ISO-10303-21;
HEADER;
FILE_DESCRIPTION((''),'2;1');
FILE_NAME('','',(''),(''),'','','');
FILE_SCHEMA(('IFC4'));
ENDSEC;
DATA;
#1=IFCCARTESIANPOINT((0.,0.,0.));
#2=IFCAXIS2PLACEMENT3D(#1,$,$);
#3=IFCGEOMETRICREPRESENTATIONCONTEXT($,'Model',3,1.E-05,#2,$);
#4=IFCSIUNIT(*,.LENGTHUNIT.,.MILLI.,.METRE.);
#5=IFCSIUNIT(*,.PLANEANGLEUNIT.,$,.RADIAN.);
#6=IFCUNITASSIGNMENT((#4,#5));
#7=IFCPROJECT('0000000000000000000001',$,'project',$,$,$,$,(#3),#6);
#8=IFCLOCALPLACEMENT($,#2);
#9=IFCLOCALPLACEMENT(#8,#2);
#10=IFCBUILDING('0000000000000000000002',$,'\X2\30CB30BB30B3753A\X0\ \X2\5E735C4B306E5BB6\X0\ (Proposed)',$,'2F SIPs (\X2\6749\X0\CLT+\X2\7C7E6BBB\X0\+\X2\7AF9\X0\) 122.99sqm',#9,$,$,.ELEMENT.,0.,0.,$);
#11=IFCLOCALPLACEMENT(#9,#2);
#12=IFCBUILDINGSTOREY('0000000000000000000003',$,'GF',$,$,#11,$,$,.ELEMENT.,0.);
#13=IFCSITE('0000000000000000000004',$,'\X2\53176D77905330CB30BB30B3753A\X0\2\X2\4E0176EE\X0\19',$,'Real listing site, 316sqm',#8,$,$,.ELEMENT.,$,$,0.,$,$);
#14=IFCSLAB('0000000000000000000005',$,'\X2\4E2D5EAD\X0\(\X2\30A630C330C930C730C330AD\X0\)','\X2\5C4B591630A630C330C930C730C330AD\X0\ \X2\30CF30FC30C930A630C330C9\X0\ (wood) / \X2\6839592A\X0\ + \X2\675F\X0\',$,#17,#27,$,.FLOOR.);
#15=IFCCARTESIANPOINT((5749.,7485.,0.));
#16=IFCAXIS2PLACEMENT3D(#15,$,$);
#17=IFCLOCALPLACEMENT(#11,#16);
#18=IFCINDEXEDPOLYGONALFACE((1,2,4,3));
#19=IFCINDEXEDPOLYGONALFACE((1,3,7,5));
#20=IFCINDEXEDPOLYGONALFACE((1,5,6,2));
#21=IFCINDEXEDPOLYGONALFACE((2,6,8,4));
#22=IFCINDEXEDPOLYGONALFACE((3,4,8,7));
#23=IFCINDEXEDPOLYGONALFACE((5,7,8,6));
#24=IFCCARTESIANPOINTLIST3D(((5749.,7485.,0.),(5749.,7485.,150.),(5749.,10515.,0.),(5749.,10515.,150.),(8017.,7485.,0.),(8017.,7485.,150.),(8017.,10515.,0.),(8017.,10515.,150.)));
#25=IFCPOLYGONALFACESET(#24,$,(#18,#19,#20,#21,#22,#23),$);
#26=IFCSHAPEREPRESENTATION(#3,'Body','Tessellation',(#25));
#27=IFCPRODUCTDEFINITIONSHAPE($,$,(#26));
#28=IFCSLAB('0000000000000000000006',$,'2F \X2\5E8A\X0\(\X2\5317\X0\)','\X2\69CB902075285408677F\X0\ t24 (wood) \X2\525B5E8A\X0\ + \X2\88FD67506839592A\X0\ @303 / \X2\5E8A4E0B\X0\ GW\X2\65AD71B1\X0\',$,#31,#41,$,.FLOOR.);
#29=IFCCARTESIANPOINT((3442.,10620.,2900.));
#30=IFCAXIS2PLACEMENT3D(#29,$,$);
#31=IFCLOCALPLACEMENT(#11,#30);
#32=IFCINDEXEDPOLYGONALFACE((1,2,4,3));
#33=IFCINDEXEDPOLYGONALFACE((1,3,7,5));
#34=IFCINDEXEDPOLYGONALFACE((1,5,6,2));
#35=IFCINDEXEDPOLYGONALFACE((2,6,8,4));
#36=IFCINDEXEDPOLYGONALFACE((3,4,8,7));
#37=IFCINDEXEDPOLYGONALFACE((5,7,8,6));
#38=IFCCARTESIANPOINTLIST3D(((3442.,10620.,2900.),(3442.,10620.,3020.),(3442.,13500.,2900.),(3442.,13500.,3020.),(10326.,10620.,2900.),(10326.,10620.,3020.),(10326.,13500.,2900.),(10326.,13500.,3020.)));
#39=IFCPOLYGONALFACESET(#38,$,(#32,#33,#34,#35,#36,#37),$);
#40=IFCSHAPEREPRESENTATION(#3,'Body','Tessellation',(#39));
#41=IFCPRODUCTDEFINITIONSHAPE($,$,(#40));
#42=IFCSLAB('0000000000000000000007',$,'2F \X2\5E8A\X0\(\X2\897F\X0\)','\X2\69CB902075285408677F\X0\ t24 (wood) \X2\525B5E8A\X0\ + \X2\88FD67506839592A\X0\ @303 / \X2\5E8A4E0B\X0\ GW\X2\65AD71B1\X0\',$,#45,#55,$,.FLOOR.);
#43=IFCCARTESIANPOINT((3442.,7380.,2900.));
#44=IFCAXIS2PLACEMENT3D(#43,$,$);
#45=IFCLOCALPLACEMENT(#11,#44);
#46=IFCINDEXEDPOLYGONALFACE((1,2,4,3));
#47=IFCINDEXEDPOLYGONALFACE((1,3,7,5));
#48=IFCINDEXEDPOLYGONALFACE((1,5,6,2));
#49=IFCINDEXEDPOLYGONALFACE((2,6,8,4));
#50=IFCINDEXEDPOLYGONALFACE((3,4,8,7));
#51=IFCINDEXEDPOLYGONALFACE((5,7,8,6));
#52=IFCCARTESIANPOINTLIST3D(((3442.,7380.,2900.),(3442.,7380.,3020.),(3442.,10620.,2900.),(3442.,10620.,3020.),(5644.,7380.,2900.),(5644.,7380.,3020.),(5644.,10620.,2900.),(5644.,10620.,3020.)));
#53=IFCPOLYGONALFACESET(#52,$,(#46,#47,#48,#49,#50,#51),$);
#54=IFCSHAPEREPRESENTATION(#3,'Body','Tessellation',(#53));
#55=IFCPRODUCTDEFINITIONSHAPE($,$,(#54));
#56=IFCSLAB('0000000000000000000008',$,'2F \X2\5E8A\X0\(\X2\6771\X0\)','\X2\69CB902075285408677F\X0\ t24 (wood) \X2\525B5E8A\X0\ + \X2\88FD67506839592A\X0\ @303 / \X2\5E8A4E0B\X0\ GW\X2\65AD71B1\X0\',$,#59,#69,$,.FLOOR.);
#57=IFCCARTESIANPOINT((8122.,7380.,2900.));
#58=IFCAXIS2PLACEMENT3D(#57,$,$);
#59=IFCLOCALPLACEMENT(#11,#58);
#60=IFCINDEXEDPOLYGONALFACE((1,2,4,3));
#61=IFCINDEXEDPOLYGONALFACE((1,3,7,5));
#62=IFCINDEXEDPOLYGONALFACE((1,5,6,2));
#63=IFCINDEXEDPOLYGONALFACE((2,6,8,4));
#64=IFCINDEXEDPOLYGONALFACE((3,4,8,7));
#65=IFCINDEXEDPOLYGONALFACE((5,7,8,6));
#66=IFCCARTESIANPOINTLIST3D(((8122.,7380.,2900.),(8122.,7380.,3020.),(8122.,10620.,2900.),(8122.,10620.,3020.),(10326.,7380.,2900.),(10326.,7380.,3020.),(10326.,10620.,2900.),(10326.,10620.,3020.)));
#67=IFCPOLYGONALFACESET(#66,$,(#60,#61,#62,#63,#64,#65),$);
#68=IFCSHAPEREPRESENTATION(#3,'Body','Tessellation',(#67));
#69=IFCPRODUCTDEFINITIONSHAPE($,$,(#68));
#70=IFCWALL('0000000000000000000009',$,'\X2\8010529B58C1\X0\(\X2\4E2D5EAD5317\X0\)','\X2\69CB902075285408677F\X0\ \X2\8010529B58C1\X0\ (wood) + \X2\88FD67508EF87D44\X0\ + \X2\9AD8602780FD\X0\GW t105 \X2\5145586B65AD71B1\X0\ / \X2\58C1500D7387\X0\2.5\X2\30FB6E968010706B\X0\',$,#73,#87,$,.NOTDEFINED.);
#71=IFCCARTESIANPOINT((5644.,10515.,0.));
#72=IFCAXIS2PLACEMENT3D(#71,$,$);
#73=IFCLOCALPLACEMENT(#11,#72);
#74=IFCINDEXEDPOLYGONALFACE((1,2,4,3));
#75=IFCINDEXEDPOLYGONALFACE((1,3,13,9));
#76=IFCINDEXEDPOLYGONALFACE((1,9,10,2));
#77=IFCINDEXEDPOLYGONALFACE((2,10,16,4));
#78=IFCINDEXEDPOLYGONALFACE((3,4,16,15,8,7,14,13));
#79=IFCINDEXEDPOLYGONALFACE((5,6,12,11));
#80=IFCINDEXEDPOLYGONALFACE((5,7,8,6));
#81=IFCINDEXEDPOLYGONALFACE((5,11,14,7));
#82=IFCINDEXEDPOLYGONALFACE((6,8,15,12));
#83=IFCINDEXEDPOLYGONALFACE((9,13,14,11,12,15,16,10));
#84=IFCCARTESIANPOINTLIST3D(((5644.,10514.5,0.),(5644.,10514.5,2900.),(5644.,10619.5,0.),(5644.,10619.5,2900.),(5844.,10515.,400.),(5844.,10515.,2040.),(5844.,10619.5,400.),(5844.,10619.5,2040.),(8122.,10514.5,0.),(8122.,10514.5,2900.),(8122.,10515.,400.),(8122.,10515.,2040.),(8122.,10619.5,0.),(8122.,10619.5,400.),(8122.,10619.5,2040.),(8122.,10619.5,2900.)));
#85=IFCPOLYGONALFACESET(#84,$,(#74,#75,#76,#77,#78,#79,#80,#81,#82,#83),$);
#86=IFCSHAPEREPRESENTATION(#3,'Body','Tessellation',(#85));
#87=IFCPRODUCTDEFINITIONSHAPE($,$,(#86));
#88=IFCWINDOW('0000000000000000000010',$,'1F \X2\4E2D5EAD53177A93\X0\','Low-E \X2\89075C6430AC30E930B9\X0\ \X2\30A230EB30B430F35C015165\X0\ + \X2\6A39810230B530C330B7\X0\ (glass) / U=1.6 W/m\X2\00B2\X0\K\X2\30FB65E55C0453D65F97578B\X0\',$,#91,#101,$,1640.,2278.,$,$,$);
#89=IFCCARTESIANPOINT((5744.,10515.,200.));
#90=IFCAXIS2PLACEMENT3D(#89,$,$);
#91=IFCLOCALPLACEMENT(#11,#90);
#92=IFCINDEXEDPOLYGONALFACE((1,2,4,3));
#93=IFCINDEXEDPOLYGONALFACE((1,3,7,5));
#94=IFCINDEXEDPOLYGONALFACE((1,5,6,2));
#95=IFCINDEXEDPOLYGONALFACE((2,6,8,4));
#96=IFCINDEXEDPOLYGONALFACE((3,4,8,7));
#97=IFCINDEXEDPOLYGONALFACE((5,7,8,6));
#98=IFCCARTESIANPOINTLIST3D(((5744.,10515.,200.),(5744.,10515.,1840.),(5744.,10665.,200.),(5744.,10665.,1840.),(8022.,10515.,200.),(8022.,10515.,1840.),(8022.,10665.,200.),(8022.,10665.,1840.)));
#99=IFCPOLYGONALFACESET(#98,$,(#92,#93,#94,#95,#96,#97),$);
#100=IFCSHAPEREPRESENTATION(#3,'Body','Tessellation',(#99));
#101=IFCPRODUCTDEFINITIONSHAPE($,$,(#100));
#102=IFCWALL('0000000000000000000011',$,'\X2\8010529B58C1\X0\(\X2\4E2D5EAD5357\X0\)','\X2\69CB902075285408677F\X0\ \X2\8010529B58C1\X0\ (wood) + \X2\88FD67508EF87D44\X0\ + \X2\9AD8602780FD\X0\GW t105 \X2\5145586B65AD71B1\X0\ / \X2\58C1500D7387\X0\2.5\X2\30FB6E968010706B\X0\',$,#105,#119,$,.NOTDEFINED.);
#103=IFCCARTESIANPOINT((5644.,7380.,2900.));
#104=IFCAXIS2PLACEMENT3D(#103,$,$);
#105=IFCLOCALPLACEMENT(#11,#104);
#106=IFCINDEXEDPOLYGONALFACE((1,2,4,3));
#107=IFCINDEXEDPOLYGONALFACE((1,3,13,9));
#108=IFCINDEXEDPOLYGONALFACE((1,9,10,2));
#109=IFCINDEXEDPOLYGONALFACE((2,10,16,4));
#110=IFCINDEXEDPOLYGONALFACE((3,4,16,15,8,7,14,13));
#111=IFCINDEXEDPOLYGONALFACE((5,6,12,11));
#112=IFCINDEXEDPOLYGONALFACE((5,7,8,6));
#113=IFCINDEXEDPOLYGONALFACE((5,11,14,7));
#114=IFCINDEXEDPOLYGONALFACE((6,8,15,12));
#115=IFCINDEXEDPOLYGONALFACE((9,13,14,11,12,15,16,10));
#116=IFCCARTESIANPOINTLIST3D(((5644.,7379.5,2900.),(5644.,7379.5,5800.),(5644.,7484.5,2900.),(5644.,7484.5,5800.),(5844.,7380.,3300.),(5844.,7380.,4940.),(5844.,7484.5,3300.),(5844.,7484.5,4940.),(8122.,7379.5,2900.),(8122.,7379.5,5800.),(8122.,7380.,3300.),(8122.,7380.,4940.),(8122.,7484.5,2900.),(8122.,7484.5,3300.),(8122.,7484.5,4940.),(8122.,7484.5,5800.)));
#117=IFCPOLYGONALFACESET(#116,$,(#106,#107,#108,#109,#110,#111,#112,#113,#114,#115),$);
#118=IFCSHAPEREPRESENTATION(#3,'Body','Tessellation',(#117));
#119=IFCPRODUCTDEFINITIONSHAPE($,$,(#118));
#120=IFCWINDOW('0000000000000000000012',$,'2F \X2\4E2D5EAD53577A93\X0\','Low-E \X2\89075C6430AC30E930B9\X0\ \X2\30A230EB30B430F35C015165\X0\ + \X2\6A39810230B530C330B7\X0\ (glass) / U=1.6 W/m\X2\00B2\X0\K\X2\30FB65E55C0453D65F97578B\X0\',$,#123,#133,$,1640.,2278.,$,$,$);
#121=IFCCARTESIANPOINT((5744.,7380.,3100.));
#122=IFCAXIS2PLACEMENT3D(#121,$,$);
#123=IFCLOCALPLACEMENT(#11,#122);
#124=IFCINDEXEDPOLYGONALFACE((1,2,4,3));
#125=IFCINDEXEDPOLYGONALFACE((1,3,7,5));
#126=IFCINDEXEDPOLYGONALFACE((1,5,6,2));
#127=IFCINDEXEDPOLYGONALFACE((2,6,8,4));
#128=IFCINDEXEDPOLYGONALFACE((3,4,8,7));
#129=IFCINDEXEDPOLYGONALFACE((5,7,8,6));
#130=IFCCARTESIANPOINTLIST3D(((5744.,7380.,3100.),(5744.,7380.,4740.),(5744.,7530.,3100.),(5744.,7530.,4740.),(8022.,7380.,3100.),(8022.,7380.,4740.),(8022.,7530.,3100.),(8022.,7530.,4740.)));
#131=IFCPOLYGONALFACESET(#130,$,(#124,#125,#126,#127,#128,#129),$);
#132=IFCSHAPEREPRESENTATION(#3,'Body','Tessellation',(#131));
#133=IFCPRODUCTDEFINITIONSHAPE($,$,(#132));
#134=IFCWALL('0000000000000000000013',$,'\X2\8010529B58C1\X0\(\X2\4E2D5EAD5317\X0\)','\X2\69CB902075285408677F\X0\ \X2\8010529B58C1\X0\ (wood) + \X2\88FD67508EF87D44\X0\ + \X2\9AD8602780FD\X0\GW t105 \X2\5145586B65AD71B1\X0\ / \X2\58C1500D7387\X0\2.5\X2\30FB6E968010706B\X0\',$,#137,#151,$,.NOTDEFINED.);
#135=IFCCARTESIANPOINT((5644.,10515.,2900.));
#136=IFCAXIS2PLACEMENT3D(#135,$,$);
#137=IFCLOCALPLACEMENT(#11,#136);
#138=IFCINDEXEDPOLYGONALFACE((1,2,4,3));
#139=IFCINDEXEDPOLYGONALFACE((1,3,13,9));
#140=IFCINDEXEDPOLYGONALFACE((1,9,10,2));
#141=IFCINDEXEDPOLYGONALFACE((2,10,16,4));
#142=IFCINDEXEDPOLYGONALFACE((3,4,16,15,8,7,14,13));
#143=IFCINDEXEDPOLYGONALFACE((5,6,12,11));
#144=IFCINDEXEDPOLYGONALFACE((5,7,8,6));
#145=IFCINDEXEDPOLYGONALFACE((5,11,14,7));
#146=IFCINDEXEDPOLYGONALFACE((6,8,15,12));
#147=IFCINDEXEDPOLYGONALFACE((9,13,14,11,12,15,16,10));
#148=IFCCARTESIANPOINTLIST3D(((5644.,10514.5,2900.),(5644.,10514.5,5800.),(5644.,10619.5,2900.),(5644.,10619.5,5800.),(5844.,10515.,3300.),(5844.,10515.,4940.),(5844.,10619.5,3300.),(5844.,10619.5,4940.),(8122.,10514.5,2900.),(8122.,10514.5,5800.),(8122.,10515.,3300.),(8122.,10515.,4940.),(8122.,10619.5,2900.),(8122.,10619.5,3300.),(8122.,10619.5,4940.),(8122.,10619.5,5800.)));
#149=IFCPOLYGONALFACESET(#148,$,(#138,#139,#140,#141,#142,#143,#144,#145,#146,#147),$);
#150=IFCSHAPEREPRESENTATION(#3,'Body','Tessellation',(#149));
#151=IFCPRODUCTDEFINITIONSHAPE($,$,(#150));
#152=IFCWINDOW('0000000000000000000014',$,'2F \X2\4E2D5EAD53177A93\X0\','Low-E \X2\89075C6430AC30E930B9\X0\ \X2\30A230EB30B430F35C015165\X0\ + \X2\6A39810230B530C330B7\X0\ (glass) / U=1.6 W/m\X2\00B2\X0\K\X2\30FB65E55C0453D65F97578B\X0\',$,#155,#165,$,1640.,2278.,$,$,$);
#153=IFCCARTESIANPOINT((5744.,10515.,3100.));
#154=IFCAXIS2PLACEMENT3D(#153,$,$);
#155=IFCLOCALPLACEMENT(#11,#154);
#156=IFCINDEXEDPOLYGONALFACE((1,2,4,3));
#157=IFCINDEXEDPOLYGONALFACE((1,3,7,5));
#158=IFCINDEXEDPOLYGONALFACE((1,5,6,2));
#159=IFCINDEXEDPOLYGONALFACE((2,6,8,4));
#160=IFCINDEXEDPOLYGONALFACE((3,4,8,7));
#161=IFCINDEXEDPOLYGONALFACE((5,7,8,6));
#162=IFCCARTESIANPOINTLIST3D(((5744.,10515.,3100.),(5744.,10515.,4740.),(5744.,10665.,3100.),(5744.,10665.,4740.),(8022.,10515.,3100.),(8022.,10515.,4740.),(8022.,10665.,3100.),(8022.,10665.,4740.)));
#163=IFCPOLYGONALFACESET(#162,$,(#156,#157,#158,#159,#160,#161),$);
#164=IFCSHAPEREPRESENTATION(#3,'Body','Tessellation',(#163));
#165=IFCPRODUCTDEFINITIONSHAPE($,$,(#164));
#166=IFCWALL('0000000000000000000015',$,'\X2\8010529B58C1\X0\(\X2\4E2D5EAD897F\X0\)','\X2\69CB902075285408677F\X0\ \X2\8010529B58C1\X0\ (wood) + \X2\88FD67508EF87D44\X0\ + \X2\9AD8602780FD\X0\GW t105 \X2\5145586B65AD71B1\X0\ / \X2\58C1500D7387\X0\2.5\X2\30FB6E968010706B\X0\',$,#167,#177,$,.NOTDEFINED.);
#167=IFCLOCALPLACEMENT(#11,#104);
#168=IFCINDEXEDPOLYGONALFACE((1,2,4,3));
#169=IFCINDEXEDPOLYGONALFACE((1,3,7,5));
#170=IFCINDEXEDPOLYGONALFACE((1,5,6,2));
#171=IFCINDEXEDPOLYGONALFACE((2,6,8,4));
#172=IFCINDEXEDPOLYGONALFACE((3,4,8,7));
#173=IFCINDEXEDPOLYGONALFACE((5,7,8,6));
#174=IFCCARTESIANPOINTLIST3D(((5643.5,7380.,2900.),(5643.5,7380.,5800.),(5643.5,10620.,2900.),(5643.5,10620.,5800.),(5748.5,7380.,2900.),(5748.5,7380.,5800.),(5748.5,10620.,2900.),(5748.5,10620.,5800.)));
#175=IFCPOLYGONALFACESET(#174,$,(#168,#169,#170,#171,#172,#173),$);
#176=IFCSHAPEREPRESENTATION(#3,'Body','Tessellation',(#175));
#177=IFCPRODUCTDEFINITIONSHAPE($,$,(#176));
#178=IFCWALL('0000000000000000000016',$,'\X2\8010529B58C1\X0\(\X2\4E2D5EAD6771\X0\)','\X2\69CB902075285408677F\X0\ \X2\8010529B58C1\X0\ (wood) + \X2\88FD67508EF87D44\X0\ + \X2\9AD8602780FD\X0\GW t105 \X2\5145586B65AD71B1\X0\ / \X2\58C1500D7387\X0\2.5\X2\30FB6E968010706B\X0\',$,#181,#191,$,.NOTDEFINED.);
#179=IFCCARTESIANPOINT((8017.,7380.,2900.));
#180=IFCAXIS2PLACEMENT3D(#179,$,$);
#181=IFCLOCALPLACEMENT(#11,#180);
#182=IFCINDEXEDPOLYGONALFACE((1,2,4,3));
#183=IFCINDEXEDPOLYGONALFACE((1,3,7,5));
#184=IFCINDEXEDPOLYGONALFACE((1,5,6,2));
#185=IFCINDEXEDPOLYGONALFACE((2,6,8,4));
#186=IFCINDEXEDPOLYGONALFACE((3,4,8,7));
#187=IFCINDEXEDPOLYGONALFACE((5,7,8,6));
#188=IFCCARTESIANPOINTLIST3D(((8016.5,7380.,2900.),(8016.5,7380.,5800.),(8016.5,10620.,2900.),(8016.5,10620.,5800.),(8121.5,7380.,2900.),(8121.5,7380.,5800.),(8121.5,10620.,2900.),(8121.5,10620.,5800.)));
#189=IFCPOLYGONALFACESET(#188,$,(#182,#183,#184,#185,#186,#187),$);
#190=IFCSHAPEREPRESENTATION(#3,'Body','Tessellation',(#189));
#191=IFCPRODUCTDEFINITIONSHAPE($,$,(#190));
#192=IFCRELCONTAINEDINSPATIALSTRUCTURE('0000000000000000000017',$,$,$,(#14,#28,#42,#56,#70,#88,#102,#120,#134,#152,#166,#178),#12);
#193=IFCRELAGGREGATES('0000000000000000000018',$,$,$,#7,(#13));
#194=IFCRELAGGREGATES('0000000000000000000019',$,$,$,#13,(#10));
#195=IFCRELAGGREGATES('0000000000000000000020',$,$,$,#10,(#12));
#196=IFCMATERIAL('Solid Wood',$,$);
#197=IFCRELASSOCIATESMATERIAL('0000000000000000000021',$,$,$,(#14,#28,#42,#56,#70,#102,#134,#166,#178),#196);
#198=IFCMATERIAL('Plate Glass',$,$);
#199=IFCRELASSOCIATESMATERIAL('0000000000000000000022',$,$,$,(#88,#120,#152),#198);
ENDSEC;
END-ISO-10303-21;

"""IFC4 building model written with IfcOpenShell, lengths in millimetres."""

from ifc_helpers import new_model, si_unit, frame, frame_2d, origin, place, context, project, spatial, rectangle, extrude, material, element, fill, save


model = new_model("IFC4")

# Units and contexts
model_context = context("Model", 3, precision=1e-05, world=origin())
ifc_project = project(units=[si_unit("LENGTHUNIT", "METRE", prefix="MILLI"), si_unit("PLANEANGLEUNIT", "RADIAN")], contexts=[model_context])

# Site, building, storey
site_placement = place(None, origin())
site = spatial("IfcSite", under=ifc_project, at=site_placement, Name="北海道ニセコ町2丁目19", ObjectType="Real listing site, 316sqm", CompositionType="ELEMENT", RefElevation=0.0)
building_placement = place(site_placement, origin())
building = spatial("IfcBuilding", under=site, at=building_placement, Name="ニセコ町 平屋の家 (Proposed)", ObjectType="2F SIPs (杉CLT+籾殻+竹) 122.99sqm", CompositionType="ELEMENT", ElevationOfRefHeight=0.0, ElevationOfTerrain=0.0)
storey_placement = place(building_placement, origin())
storey = spatial("IfcBuildingStorey", under=building, at=storey_placement, Name="GF", CompositionType="ELEMENT", Elevation=0.0)

# Slabs
ifc_material_1 = material(Name="Solid Wood")
slab_1_placement = place(storey_placement, frame((5749.0, 7485.0, 0.0)))
element("IfcSlab", 1, at=slab_1_placement, inside=storey, material=ifc_material_1, Name="中庭(ウッドデッキ)", Description="屋外ウッドデッキ ハードウッド (wood) / 根太 + 束", PredefinedType="FLOOR", context=model_context, shape_type="SweptSolid", body=[
    extrude(rectangle(XDim=2268.0, YDim=3030.0, at=frame_2d((1134.0, 1515.0))), frame((5749.0, 7485.0, 0.0)), (0.0, 0.0, 1.0), 150.0),
])
slab_2_placement = place(storey_placement, frame((3442.0, 10620.0, 2900.0)))
element("IfcSlab", 2, at=slab_2_placement, inside=storey, material=ifc_material_1, Name="2F 床(北)", Description="構造用合板 t24 (wood) 剛床 + 製材根太 @303 / 床下 GW断熱", PredefinedType="FLOOR", context=model_context, shape_type="SweptSolid", body=[
    extrude(rectangle(XDim=6884.0, YDim=2880.0, at=frame_2d((3442.0, 1440.0))), frame((3442.0, 10620.0, 2900.0)), (0.0, 0.0, 1.0), 120.0),
])
slab_3_placement = place(storey_placement, frame((3442.0, 7380.0, 2900.0)))
element("IfcSlab", 3, at=slab_3_placement, inside=storey, material=ifc_material_1, Name="2F 床(西)", Description="構造用合板 t24 (wood) 剛床 + 製材根太 @303 / 床下 GW断熱", PredefinedType="FLOOR", context=model_context, shape_type="SweptSolid", body=[
    extrude(rectangle(XDim=2202.0, YDim=3240.0, at=frame_2d((1101.0, 1620.0))), frame((3442.0, 7380.0, 2900.0)), (0.0, 0.0, 1.0), 120.0),
])
slab_4_placement = place(storey_placement, frame((8122.0, 7380.0, 2900.0)))
element("IfcSlab", 4, at=slab_4_placement, inside=storey, material=ifc_material_1, Name="2F 床(東)", Description="構造用合板 t24 (wood) 剛床 + 製材根太 @303 / 床下 GW断熱", PredefinedType="FLOOR", context=model_context, shape_type="SweptSolid", body=[
    extrude(rectangle(XDim=2204.0, YDim=3240.0, at=frame_2d((1102.0, 1620.0))), frame((8122.0, 7380.0, 2900.0)), (0.0, 0.0, 1.0), 120.0),
])

# Wall, opening, window
wall_1_placement = place(storey_placement, frame((5644.0, 10515.0, 0.0)))
wall_1 = element("IfcWall", 5, at=wall_1_placement, inside=storey, material=ifc_material_1, Name="耐力壁(中庭北)", Description="構造用合板 耐力壁 (wood) + 製材軸組 + 高性能GW t105 充填断熱 / 壁倍率2.5・準耐火", PredefinedType="NOTDEFINED", context=model_context, shape_type="SweptSolid", body=[
    extrude(rectangle(XDim=2478.0, YDim=105.0, at=frame_2d((1239.0, 52.0))), frame((5644.0, 10515.0, 0.0)), (0.0, 0.0, 1.0), 2900.0),
])
opening_1_placement = place(storey_placement, frame((5744.0, 10515.0, 200.0)))
opening_1 = element("IfcOpeningElement", 6, at=opening_1_placement, cuts=wall_1, PredefinedType="NOTDEFINED", context=model_context, shape_type="SweptSolid", body=[
    extrude(rectangle(XDim=2278.0, YDim=150.0, at=frame_2d((1139.0, 75.0))), frame((5744.0, 10515.0, 200.0)), (0.0, 0.0, 1.0), 1640.0),
])
ifc_material_2 = material(Name="Plate Glass")
window_1_placement = place(storey_placement, frame((5744.0, 10515.0, 200.0)))
window_1 = element("IfcWindow", 7, at=window_1_placement, inside=storey, material=ifc_material_2, Name="1F 中庭北窓", Description="Low-E 複層ガラス アルゴン封入 + 樹脂サッシ (glass) / U=1.6 W/m²K・日射取得型", OverallHeight=1640.0, OverallWidth=2278.0, context=model_context, shape_type="SweptSolid", body=[
    extrude(rectangle(XDim=2278.0, YDim=150.0, at=frame_2d((1139.0, 75.0))), frame((5744.0, 10515.0, 200.0)), (0.0, 0.0, 1.0), 1640.0),
])
fill(opening_1, window_1)

# Walls, openings, windows
wall_2_placement = place(storey_placement, frame((5644.0, 7380.0, 2900.0)))
wall_2 = element("IfcWall", 8, at=wall_2_placement, inside=storey, material=ifc_material_1, Name="耐力壁(中庭南)", Description="構造用合板 耐力壁 (wood) + 製材軸組 + 高性能GW t105 充填断熱 / 壁倍率2.5・準耐火", PredefinedType="NOTDEFINED", context=model_context, shape_type="SweptSolid", body=[
    extrude(rectangle(XDim=2478.0, YDim=105.0, at=frame_2d((1239.0, 52.0))), frame((5644.0, 7380.0, 2900.0)), (0.0, 0.0, 1.0), 2900.0),
])
opening_2_placement = place(storey_placement, frame((5744.0, 7380.0, 3100.0)))
opening_2 = element("IfcOpeningElement", 9, at=opening_2_placement, cuts=wall_2, PredefinedType="NOTDEFINED", context=model_context, shape_type="SweptSolid", body=[
    extrude(rectangle(XDim=2278.0, YDim=150.0, at=frame_2d((1139.0, 75.0))), frame((5744.0, 7380.0, 3100.0)), (0.0, 0.0, 1.0), 1640.0),
])
window_2_placement = place(storey_placement, frame((5744.0, 7380.0, 3100.0)))
window_2 = element("IfcWindow", 10, at=window_2_placement, inside=storey, material=ifc_material_2, Name="2F 中庭南窓", Description="Low-E 複層ガラス アルゴン封入 + 樹脂サッシ (glass) / U=1.6 W/m²K・日射取得型", OverallHeight=1640.0, OverallWidth=2278.0, context=model_context, shape_type="SweptSolid", body=[
    extrude(rectangle(XDim=2278.0, YDim=150.0, at=frame_2d((1139.0, 75.0))), frame((5744.0, 7380.0, 3100.0)), (0.0, 0.0, 1.0), 1640.0),
])
fill(opening_2, window_2)
wall_3_placement = place(storey_placement, frame((5644.0, 10515.0, 2900.0)))
wall_3 = element("IfcWall", 11, at=wall_3_placement, inside=storey, material=ifc_material_1, Name="耐力壁(中庭北)", Description="構造用合板 耐力壁 (wood) + 製材軸組 + 高性能GW t105 充填断熱 / 壁倍率2.5・準耐火", PredefinedType="NOTDEFINED", context=model_context, shape_type="SweptSolid", body=[
    extrude(rectangle(XDim=2478.0, YDim=105.0, at=frame_2d((1239.0, 52.0))), frame((5644.0, 10515.0, 2900.0)), (0.0, 0.0, 1.0), 2900.0),
])
opening_3_placement = place(storey_placement, frame((5744.0, 10515.0, 3100.0)))
opening_3 = element("IfcOpeningElement", 12, at=opening_3_placement, cuts=wall_3, PredefinedType="NOTDEFINED", context=model_context, shape_type="SweptSolid", body=[
    extrude(rectangle(XDim=2278.0, YDim=150.0, at=frame_2d((1139.0, 75.0))), frame((5744.0, 10515.0, 3100.0)), (0.0, 0.0, 1.0), 1640.0),
])
window_3_placement = place(storey_placement, frame((5744.0, 10515.0, 3100.0)))
window_3 = element("IfcWindow", 13, at=window_3_placement, inside=storey, material=ifc_material_2, Name="2F 中庭北窓", Description="Low-E 複層ガラス アルゴン封入 + 樹脂サッシ (glass) / U=1.6 W/m²K・日射取得型", OverallHeight=1640.0, OverallWidth=2278.0, context=model_context, shape_type="SweptSolid", body=[
    extrude(rectangle(XDim=2278.0, YDim=150.0, at=frame_2d((1139.0, 75.0))), frame((5744.0, 10515.0, 3100.0)), (0.0, 0.0, 1.0), 1640.0),
])
fill(opening_3, window_3)

# Walls
wall_4_placement = place(storey_placement, frame((5644.0, 7380.0, 2900.0)))
element("IfcWall", 14, at=wall_4_placement, inside=storey, material=ifc_material_1, Name="耐力壁(中庭西)", Description="構造用合板 耐力壁 (wood) + 製材軸組 + 高性能GW t105 充填断熱 / 壁倍率2.5・準耐火", PredefinedType="NOTDEFINED", context=model_context, shape_type="SweptSolid", body=[
    extrude(rectangle(XDim=105.0, YDim=3240.0, at=frame_2d((52.0, 1620.0))), frame((5644.0, 7380.0, 2900.0)), (0.0, 0.0, 1.0), 2900.0),
])
wall_5_placement = place(storey_placement, frame((8017.0, 7380.0, 2900.0)))
element("IfcWall", 15, at=wall_5_placement, inside=storey, material=ifc_material_1, Name="耐力壁(中庭東)", Description="構造用合板 耐力壁 (wood) + 製材軸組 + 高性能GW t105 充填断熱 / 壁倍率2.5・準耐火", PredefinedType="NOTDEFINED", context=model_context, shape_type="SweptSolid", body=[
    extrude(rectangle(XDim=105.0, YDim=3240.0, at=frame_2d((52.0, 1620.0))), frame((8017.0, 7380.0, 2900.0)), (0.0, 0.0, 1.0), 2900.0),
])

save(model, "model.ifc")
